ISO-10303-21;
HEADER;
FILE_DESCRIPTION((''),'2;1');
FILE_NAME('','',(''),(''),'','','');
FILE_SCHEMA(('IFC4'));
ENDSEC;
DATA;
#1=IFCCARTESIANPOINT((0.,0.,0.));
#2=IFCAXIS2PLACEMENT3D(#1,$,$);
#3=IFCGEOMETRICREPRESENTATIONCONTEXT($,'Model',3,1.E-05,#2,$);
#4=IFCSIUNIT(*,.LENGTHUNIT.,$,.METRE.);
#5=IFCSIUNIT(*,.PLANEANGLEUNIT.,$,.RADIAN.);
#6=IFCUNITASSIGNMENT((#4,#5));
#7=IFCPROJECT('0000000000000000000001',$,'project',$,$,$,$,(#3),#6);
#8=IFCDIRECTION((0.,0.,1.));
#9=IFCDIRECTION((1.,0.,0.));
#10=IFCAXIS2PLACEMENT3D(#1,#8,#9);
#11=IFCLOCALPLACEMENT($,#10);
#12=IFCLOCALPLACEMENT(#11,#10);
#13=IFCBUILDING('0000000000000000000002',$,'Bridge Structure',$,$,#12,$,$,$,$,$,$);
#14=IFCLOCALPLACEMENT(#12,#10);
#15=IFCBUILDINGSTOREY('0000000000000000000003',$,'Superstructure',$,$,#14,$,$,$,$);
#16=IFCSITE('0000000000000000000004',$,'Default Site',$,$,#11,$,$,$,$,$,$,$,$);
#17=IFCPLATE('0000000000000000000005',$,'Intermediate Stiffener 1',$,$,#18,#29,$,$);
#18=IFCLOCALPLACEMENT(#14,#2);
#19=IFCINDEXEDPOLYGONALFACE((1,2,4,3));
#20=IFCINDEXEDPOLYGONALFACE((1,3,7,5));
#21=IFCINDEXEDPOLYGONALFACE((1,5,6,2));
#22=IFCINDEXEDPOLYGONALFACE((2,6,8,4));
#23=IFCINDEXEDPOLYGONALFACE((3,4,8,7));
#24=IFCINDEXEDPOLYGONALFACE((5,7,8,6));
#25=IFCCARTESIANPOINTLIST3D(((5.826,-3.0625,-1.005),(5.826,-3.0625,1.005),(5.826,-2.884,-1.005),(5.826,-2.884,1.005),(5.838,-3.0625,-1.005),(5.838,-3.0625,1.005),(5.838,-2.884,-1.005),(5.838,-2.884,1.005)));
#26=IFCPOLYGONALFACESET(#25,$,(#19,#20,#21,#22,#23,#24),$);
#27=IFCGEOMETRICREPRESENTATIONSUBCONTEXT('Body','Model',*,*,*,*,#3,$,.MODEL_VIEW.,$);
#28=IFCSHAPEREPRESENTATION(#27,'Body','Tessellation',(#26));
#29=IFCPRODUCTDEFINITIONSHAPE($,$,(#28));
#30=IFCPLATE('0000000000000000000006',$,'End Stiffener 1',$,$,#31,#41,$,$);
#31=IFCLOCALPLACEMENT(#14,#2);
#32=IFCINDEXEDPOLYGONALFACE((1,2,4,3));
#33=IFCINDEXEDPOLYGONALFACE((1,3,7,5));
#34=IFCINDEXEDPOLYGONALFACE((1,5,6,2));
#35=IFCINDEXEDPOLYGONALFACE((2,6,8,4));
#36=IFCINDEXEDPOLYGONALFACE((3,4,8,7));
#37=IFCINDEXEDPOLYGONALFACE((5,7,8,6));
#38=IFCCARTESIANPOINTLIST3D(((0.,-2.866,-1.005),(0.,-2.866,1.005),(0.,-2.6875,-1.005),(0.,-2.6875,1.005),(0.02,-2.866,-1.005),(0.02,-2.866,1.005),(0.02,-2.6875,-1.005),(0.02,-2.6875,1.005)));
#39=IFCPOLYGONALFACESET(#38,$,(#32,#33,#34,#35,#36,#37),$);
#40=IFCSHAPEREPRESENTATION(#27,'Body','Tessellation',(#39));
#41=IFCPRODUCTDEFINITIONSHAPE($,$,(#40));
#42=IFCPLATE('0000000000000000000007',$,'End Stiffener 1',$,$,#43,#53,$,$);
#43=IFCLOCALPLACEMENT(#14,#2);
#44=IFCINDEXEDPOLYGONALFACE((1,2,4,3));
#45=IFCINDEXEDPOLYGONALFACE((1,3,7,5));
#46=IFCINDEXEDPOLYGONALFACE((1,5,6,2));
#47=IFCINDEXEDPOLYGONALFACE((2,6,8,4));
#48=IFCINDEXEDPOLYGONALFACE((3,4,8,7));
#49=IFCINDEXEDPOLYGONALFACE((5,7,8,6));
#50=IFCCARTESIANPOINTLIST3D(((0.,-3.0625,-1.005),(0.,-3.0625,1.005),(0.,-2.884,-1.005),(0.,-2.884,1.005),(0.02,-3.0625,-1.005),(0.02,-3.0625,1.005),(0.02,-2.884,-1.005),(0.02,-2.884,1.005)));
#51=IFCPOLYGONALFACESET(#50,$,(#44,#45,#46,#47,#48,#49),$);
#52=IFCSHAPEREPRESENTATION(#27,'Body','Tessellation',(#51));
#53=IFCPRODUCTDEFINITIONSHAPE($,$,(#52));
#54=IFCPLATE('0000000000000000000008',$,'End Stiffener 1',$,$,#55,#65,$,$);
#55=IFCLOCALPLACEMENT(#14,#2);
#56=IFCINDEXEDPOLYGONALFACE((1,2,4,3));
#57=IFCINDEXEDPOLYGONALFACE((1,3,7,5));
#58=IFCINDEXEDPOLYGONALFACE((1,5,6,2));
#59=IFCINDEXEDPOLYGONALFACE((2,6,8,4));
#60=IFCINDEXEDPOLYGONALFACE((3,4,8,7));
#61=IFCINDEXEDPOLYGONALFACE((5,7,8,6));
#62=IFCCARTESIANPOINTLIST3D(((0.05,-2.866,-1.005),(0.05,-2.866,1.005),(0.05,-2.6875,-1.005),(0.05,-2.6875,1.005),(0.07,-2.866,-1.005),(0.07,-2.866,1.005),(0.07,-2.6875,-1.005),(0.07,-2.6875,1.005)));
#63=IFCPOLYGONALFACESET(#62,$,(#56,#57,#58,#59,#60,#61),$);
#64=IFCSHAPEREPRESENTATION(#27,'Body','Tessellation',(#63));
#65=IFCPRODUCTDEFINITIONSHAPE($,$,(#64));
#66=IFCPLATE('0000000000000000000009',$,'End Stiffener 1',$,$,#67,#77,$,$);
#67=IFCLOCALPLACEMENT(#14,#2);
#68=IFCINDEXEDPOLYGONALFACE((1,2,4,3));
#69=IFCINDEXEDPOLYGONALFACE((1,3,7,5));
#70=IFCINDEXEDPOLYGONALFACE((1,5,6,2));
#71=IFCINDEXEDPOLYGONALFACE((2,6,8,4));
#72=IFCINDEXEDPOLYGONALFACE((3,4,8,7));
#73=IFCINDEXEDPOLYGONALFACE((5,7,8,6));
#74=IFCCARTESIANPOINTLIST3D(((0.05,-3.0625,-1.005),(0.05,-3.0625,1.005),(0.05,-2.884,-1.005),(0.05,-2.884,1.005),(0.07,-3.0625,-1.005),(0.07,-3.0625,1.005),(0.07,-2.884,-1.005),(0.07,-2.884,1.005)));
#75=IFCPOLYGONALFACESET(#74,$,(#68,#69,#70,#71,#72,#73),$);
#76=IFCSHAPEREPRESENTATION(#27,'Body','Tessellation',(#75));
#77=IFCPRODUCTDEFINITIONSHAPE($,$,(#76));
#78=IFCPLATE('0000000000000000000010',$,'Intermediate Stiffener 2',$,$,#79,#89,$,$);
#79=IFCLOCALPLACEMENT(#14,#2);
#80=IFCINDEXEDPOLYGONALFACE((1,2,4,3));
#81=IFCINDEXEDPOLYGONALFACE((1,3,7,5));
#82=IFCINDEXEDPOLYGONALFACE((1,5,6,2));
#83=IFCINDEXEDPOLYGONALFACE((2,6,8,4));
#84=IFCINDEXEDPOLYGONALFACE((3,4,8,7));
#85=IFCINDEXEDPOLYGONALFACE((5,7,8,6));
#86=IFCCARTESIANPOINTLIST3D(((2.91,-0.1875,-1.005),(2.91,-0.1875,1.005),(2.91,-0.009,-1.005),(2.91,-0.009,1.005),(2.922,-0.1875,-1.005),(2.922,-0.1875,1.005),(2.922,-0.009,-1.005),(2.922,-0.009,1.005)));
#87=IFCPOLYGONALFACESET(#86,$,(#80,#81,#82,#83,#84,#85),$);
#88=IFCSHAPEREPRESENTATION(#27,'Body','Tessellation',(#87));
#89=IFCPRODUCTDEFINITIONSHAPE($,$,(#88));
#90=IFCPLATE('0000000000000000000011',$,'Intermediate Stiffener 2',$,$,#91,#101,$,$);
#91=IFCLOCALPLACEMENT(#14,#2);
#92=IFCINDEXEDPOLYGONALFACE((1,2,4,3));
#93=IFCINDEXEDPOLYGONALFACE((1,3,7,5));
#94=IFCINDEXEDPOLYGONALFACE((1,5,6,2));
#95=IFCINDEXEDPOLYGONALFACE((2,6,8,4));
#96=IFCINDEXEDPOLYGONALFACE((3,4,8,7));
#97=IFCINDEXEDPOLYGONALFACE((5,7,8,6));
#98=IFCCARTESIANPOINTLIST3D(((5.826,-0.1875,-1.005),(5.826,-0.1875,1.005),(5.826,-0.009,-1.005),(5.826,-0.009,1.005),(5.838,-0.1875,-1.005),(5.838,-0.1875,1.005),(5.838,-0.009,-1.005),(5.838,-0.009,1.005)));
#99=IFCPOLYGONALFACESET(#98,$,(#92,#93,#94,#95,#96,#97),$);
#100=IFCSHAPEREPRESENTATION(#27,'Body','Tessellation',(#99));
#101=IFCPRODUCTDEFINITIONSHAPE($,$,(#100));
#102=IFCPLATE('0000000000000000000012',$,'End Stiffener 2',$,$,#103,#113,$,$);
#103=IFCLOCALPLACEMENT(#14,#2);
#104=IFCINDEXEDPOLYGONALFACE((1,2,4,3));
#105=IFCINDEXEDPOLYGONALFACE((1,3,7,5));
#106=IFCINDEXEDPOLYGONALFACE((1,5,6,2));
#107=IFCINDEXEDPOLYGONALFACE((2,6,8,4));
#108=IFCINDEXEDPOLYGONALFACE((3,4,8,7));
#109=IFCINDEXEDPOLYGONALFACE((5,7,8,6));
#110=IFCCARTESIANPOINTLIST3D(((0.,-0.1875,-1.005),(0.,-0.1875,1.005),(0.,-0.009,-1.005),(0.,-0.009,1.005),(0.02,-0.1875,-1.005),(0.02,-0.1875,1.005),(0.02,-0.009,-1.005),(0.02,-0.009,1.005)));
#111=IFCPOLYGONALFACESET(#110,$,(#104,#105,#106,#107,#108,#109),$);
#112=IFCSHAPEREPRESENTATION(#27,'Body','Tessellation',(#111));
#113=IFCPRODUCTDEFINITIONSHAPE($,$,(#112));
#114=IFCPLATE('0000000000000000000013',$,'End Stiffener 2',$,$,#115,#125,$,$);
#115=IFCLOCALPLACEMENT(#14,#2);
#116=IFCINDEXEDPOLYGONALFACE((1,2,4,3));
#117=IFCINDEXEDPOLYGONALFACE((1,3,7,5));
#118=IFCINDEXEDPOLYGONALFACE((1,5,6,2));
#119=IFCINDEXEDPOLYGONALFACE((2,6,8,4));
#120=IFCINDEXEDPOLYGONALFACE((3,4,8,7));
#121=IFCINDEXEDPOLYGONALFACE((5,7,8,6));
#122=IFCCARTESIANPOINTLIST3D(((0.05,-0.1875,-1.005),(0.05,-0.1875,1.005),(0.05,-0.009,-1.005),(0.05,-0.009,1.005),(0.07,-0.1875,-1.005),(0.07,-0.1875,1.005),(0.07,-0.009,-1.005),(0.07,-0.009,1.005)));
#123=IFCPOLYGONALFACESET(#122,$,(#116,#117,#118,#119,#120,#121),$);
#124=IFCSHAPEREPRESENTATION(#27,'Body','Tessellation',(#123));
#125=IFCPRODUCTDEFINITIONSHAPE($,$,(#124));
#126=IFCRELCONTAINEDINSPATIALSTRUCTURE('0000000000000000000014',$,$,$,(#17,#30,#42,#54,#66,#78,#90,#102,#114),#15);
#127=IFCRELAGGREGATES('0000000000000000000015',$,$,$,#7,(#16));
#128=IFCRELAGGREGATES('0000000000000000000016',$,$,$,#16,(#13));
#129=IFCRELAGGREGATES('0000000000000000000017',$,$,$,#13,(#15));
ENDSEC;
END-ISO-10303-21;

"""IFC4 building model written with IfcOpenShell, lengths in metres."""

from ifc_helpers import new_model, si_unit, frame, origin, origin_with_axes, origin_2d_with_axis, place, context, subcontext, project, spatial, rectangle, extrude, element, save


model = new_model("IFC4")

# Units and contexts
model_context = context("Model", 3, precision=1e-05, world=origin())
body_context = subcontext(model_context, "Body", "Model", "MODEL_VIEW")
ifc_project = project(units=[si_unit("LENGTHUNIT", "METRE"), si_unit("PLANEANGLEUNIT", "RADIAN")], contexts=[model_context])

# Site, building, storey
site_placement = place(None, origin_with_axes())
site = spatial("IfcSite", under=ifc_project, at=site_placement, Name="Default Site")
building_placement = place(site_placement, origin_with_axes())
building = spatial("IfcBuilding", under=site, at=building_placement, Name="Bridge Structure")
storey_placement = place(building_placement, origin_with_axes())
storey = spatial("IfcBuildingStorey", under=building, at=storey_placement, Name="Superstructure")

# Plates
for number, where, z_axis, x_axis, name in (
    (1, (5.832, -2.9733, -1.005), (0.0, 0.0, 1.0), (1.0, 0.0, 0.0), "Intermediate Stiffener 1"),
):
    element("IfcPlate", number, at=place(storey_placement, frame(where, z_axis=z_axis, x_axis=x_axis)), inside=storey, Name=name, context=body_context, shape_type="SweptSolid", body=[
        extrude(rectangle(XDim=0.012, YDim=0.1785, at=origin_2d_with_axis()), origin_with_axes(), (0.0, 0.0, 1.0), 2.01),
    ])
for number, where, z_axis, x_axis, name in (
    (2, (0.01, -2.7768, -1.005), (0.0, 0.0, 1.0), (1.0, 0.0, 0.0), "End Stiffener 1"),
    (3, (0.01, -2.9733, -1.005), (0.0, 0.0, 1.0), (1.0, 0.0, 0.0), "End Stiffener 1"),
    (4, (0.06, -2.7768, -1.005), (0.0, 0.0, 1.0), (1.0, 0.0, 0.0), "End Stiffener 1"),
    (5, (0.06, -2.9733, -1.005), (0.0, 0.0, 1.0), (1.0, 0.0, 0.0), "End Stiffener 1"),
):
    element("IfcPlate", number, at=place(storey_placement, frame(where, z_axis=z_axis, x_axis=x_axis)), inside=storey, Name=name, context=body_context, shape_type="SweptSolid", body=[
        extrude(rectangle(XDim=0.02, YDim=0.1785, at=origin_2d_with_axis()), origin_with_axes(), (0.0, 0.0, 1.0), 2.01),
    ])
for number, where, z_axis, x_axis, name in (
    (6, (2.916, -0.0983, -1.005), (0.0, 0.0, 1.0), (1.0, 0.0, 0.0), "Intermediate Stiffener 2"),
    (7, (5.832, -0.0983, -1.005), (0.0, 0.0, 1.0), (1.0, 0.0, 0.0), "Intermediate Stiffener 2"),
):
    element("IfcPlate", number, at=place(storey_placement, frame(where, z_axis=z_axis, x_axis=x_axis)), inside=storey, Name=name, context=body_context, shape_type="SweptSolid", body=[
        extrude(rectangle(XDim=0.012, YDim=0.1785, at=origin_2d_with_axis()), origin_with_axes(), (0.0, 0.0, 1.0), 2.01),
    ])
for number, where, z_axis, x_axis, name in (
    (8, (0.01, -0.0983, -1.005), (0.0, 0.0, 1.0), (1.0, 0.0, 0.0), "End Stiffener 2"),
    (9, (0.06, -0.0983, -1.005), (0.0, 0.0, 1.0), (1.0, 0.0, 0.0), "End Stiffener 2"),
):
    element("IfcPlate", number, at=place(storey_placement, frame(where, z_axis=z_axis, x_axis=x_axis)), inside=storey, Name=name, context=body_context, shape_type="SweptSolid", body=[
        extrude(rectangle(XDim=0.02, YDim=0.1785, at=origin_2d_with_axis()), origin_with_axes(), (0.0, 0.0, 1.0), 2.01),
    ])

save(model, "model.ifc")
